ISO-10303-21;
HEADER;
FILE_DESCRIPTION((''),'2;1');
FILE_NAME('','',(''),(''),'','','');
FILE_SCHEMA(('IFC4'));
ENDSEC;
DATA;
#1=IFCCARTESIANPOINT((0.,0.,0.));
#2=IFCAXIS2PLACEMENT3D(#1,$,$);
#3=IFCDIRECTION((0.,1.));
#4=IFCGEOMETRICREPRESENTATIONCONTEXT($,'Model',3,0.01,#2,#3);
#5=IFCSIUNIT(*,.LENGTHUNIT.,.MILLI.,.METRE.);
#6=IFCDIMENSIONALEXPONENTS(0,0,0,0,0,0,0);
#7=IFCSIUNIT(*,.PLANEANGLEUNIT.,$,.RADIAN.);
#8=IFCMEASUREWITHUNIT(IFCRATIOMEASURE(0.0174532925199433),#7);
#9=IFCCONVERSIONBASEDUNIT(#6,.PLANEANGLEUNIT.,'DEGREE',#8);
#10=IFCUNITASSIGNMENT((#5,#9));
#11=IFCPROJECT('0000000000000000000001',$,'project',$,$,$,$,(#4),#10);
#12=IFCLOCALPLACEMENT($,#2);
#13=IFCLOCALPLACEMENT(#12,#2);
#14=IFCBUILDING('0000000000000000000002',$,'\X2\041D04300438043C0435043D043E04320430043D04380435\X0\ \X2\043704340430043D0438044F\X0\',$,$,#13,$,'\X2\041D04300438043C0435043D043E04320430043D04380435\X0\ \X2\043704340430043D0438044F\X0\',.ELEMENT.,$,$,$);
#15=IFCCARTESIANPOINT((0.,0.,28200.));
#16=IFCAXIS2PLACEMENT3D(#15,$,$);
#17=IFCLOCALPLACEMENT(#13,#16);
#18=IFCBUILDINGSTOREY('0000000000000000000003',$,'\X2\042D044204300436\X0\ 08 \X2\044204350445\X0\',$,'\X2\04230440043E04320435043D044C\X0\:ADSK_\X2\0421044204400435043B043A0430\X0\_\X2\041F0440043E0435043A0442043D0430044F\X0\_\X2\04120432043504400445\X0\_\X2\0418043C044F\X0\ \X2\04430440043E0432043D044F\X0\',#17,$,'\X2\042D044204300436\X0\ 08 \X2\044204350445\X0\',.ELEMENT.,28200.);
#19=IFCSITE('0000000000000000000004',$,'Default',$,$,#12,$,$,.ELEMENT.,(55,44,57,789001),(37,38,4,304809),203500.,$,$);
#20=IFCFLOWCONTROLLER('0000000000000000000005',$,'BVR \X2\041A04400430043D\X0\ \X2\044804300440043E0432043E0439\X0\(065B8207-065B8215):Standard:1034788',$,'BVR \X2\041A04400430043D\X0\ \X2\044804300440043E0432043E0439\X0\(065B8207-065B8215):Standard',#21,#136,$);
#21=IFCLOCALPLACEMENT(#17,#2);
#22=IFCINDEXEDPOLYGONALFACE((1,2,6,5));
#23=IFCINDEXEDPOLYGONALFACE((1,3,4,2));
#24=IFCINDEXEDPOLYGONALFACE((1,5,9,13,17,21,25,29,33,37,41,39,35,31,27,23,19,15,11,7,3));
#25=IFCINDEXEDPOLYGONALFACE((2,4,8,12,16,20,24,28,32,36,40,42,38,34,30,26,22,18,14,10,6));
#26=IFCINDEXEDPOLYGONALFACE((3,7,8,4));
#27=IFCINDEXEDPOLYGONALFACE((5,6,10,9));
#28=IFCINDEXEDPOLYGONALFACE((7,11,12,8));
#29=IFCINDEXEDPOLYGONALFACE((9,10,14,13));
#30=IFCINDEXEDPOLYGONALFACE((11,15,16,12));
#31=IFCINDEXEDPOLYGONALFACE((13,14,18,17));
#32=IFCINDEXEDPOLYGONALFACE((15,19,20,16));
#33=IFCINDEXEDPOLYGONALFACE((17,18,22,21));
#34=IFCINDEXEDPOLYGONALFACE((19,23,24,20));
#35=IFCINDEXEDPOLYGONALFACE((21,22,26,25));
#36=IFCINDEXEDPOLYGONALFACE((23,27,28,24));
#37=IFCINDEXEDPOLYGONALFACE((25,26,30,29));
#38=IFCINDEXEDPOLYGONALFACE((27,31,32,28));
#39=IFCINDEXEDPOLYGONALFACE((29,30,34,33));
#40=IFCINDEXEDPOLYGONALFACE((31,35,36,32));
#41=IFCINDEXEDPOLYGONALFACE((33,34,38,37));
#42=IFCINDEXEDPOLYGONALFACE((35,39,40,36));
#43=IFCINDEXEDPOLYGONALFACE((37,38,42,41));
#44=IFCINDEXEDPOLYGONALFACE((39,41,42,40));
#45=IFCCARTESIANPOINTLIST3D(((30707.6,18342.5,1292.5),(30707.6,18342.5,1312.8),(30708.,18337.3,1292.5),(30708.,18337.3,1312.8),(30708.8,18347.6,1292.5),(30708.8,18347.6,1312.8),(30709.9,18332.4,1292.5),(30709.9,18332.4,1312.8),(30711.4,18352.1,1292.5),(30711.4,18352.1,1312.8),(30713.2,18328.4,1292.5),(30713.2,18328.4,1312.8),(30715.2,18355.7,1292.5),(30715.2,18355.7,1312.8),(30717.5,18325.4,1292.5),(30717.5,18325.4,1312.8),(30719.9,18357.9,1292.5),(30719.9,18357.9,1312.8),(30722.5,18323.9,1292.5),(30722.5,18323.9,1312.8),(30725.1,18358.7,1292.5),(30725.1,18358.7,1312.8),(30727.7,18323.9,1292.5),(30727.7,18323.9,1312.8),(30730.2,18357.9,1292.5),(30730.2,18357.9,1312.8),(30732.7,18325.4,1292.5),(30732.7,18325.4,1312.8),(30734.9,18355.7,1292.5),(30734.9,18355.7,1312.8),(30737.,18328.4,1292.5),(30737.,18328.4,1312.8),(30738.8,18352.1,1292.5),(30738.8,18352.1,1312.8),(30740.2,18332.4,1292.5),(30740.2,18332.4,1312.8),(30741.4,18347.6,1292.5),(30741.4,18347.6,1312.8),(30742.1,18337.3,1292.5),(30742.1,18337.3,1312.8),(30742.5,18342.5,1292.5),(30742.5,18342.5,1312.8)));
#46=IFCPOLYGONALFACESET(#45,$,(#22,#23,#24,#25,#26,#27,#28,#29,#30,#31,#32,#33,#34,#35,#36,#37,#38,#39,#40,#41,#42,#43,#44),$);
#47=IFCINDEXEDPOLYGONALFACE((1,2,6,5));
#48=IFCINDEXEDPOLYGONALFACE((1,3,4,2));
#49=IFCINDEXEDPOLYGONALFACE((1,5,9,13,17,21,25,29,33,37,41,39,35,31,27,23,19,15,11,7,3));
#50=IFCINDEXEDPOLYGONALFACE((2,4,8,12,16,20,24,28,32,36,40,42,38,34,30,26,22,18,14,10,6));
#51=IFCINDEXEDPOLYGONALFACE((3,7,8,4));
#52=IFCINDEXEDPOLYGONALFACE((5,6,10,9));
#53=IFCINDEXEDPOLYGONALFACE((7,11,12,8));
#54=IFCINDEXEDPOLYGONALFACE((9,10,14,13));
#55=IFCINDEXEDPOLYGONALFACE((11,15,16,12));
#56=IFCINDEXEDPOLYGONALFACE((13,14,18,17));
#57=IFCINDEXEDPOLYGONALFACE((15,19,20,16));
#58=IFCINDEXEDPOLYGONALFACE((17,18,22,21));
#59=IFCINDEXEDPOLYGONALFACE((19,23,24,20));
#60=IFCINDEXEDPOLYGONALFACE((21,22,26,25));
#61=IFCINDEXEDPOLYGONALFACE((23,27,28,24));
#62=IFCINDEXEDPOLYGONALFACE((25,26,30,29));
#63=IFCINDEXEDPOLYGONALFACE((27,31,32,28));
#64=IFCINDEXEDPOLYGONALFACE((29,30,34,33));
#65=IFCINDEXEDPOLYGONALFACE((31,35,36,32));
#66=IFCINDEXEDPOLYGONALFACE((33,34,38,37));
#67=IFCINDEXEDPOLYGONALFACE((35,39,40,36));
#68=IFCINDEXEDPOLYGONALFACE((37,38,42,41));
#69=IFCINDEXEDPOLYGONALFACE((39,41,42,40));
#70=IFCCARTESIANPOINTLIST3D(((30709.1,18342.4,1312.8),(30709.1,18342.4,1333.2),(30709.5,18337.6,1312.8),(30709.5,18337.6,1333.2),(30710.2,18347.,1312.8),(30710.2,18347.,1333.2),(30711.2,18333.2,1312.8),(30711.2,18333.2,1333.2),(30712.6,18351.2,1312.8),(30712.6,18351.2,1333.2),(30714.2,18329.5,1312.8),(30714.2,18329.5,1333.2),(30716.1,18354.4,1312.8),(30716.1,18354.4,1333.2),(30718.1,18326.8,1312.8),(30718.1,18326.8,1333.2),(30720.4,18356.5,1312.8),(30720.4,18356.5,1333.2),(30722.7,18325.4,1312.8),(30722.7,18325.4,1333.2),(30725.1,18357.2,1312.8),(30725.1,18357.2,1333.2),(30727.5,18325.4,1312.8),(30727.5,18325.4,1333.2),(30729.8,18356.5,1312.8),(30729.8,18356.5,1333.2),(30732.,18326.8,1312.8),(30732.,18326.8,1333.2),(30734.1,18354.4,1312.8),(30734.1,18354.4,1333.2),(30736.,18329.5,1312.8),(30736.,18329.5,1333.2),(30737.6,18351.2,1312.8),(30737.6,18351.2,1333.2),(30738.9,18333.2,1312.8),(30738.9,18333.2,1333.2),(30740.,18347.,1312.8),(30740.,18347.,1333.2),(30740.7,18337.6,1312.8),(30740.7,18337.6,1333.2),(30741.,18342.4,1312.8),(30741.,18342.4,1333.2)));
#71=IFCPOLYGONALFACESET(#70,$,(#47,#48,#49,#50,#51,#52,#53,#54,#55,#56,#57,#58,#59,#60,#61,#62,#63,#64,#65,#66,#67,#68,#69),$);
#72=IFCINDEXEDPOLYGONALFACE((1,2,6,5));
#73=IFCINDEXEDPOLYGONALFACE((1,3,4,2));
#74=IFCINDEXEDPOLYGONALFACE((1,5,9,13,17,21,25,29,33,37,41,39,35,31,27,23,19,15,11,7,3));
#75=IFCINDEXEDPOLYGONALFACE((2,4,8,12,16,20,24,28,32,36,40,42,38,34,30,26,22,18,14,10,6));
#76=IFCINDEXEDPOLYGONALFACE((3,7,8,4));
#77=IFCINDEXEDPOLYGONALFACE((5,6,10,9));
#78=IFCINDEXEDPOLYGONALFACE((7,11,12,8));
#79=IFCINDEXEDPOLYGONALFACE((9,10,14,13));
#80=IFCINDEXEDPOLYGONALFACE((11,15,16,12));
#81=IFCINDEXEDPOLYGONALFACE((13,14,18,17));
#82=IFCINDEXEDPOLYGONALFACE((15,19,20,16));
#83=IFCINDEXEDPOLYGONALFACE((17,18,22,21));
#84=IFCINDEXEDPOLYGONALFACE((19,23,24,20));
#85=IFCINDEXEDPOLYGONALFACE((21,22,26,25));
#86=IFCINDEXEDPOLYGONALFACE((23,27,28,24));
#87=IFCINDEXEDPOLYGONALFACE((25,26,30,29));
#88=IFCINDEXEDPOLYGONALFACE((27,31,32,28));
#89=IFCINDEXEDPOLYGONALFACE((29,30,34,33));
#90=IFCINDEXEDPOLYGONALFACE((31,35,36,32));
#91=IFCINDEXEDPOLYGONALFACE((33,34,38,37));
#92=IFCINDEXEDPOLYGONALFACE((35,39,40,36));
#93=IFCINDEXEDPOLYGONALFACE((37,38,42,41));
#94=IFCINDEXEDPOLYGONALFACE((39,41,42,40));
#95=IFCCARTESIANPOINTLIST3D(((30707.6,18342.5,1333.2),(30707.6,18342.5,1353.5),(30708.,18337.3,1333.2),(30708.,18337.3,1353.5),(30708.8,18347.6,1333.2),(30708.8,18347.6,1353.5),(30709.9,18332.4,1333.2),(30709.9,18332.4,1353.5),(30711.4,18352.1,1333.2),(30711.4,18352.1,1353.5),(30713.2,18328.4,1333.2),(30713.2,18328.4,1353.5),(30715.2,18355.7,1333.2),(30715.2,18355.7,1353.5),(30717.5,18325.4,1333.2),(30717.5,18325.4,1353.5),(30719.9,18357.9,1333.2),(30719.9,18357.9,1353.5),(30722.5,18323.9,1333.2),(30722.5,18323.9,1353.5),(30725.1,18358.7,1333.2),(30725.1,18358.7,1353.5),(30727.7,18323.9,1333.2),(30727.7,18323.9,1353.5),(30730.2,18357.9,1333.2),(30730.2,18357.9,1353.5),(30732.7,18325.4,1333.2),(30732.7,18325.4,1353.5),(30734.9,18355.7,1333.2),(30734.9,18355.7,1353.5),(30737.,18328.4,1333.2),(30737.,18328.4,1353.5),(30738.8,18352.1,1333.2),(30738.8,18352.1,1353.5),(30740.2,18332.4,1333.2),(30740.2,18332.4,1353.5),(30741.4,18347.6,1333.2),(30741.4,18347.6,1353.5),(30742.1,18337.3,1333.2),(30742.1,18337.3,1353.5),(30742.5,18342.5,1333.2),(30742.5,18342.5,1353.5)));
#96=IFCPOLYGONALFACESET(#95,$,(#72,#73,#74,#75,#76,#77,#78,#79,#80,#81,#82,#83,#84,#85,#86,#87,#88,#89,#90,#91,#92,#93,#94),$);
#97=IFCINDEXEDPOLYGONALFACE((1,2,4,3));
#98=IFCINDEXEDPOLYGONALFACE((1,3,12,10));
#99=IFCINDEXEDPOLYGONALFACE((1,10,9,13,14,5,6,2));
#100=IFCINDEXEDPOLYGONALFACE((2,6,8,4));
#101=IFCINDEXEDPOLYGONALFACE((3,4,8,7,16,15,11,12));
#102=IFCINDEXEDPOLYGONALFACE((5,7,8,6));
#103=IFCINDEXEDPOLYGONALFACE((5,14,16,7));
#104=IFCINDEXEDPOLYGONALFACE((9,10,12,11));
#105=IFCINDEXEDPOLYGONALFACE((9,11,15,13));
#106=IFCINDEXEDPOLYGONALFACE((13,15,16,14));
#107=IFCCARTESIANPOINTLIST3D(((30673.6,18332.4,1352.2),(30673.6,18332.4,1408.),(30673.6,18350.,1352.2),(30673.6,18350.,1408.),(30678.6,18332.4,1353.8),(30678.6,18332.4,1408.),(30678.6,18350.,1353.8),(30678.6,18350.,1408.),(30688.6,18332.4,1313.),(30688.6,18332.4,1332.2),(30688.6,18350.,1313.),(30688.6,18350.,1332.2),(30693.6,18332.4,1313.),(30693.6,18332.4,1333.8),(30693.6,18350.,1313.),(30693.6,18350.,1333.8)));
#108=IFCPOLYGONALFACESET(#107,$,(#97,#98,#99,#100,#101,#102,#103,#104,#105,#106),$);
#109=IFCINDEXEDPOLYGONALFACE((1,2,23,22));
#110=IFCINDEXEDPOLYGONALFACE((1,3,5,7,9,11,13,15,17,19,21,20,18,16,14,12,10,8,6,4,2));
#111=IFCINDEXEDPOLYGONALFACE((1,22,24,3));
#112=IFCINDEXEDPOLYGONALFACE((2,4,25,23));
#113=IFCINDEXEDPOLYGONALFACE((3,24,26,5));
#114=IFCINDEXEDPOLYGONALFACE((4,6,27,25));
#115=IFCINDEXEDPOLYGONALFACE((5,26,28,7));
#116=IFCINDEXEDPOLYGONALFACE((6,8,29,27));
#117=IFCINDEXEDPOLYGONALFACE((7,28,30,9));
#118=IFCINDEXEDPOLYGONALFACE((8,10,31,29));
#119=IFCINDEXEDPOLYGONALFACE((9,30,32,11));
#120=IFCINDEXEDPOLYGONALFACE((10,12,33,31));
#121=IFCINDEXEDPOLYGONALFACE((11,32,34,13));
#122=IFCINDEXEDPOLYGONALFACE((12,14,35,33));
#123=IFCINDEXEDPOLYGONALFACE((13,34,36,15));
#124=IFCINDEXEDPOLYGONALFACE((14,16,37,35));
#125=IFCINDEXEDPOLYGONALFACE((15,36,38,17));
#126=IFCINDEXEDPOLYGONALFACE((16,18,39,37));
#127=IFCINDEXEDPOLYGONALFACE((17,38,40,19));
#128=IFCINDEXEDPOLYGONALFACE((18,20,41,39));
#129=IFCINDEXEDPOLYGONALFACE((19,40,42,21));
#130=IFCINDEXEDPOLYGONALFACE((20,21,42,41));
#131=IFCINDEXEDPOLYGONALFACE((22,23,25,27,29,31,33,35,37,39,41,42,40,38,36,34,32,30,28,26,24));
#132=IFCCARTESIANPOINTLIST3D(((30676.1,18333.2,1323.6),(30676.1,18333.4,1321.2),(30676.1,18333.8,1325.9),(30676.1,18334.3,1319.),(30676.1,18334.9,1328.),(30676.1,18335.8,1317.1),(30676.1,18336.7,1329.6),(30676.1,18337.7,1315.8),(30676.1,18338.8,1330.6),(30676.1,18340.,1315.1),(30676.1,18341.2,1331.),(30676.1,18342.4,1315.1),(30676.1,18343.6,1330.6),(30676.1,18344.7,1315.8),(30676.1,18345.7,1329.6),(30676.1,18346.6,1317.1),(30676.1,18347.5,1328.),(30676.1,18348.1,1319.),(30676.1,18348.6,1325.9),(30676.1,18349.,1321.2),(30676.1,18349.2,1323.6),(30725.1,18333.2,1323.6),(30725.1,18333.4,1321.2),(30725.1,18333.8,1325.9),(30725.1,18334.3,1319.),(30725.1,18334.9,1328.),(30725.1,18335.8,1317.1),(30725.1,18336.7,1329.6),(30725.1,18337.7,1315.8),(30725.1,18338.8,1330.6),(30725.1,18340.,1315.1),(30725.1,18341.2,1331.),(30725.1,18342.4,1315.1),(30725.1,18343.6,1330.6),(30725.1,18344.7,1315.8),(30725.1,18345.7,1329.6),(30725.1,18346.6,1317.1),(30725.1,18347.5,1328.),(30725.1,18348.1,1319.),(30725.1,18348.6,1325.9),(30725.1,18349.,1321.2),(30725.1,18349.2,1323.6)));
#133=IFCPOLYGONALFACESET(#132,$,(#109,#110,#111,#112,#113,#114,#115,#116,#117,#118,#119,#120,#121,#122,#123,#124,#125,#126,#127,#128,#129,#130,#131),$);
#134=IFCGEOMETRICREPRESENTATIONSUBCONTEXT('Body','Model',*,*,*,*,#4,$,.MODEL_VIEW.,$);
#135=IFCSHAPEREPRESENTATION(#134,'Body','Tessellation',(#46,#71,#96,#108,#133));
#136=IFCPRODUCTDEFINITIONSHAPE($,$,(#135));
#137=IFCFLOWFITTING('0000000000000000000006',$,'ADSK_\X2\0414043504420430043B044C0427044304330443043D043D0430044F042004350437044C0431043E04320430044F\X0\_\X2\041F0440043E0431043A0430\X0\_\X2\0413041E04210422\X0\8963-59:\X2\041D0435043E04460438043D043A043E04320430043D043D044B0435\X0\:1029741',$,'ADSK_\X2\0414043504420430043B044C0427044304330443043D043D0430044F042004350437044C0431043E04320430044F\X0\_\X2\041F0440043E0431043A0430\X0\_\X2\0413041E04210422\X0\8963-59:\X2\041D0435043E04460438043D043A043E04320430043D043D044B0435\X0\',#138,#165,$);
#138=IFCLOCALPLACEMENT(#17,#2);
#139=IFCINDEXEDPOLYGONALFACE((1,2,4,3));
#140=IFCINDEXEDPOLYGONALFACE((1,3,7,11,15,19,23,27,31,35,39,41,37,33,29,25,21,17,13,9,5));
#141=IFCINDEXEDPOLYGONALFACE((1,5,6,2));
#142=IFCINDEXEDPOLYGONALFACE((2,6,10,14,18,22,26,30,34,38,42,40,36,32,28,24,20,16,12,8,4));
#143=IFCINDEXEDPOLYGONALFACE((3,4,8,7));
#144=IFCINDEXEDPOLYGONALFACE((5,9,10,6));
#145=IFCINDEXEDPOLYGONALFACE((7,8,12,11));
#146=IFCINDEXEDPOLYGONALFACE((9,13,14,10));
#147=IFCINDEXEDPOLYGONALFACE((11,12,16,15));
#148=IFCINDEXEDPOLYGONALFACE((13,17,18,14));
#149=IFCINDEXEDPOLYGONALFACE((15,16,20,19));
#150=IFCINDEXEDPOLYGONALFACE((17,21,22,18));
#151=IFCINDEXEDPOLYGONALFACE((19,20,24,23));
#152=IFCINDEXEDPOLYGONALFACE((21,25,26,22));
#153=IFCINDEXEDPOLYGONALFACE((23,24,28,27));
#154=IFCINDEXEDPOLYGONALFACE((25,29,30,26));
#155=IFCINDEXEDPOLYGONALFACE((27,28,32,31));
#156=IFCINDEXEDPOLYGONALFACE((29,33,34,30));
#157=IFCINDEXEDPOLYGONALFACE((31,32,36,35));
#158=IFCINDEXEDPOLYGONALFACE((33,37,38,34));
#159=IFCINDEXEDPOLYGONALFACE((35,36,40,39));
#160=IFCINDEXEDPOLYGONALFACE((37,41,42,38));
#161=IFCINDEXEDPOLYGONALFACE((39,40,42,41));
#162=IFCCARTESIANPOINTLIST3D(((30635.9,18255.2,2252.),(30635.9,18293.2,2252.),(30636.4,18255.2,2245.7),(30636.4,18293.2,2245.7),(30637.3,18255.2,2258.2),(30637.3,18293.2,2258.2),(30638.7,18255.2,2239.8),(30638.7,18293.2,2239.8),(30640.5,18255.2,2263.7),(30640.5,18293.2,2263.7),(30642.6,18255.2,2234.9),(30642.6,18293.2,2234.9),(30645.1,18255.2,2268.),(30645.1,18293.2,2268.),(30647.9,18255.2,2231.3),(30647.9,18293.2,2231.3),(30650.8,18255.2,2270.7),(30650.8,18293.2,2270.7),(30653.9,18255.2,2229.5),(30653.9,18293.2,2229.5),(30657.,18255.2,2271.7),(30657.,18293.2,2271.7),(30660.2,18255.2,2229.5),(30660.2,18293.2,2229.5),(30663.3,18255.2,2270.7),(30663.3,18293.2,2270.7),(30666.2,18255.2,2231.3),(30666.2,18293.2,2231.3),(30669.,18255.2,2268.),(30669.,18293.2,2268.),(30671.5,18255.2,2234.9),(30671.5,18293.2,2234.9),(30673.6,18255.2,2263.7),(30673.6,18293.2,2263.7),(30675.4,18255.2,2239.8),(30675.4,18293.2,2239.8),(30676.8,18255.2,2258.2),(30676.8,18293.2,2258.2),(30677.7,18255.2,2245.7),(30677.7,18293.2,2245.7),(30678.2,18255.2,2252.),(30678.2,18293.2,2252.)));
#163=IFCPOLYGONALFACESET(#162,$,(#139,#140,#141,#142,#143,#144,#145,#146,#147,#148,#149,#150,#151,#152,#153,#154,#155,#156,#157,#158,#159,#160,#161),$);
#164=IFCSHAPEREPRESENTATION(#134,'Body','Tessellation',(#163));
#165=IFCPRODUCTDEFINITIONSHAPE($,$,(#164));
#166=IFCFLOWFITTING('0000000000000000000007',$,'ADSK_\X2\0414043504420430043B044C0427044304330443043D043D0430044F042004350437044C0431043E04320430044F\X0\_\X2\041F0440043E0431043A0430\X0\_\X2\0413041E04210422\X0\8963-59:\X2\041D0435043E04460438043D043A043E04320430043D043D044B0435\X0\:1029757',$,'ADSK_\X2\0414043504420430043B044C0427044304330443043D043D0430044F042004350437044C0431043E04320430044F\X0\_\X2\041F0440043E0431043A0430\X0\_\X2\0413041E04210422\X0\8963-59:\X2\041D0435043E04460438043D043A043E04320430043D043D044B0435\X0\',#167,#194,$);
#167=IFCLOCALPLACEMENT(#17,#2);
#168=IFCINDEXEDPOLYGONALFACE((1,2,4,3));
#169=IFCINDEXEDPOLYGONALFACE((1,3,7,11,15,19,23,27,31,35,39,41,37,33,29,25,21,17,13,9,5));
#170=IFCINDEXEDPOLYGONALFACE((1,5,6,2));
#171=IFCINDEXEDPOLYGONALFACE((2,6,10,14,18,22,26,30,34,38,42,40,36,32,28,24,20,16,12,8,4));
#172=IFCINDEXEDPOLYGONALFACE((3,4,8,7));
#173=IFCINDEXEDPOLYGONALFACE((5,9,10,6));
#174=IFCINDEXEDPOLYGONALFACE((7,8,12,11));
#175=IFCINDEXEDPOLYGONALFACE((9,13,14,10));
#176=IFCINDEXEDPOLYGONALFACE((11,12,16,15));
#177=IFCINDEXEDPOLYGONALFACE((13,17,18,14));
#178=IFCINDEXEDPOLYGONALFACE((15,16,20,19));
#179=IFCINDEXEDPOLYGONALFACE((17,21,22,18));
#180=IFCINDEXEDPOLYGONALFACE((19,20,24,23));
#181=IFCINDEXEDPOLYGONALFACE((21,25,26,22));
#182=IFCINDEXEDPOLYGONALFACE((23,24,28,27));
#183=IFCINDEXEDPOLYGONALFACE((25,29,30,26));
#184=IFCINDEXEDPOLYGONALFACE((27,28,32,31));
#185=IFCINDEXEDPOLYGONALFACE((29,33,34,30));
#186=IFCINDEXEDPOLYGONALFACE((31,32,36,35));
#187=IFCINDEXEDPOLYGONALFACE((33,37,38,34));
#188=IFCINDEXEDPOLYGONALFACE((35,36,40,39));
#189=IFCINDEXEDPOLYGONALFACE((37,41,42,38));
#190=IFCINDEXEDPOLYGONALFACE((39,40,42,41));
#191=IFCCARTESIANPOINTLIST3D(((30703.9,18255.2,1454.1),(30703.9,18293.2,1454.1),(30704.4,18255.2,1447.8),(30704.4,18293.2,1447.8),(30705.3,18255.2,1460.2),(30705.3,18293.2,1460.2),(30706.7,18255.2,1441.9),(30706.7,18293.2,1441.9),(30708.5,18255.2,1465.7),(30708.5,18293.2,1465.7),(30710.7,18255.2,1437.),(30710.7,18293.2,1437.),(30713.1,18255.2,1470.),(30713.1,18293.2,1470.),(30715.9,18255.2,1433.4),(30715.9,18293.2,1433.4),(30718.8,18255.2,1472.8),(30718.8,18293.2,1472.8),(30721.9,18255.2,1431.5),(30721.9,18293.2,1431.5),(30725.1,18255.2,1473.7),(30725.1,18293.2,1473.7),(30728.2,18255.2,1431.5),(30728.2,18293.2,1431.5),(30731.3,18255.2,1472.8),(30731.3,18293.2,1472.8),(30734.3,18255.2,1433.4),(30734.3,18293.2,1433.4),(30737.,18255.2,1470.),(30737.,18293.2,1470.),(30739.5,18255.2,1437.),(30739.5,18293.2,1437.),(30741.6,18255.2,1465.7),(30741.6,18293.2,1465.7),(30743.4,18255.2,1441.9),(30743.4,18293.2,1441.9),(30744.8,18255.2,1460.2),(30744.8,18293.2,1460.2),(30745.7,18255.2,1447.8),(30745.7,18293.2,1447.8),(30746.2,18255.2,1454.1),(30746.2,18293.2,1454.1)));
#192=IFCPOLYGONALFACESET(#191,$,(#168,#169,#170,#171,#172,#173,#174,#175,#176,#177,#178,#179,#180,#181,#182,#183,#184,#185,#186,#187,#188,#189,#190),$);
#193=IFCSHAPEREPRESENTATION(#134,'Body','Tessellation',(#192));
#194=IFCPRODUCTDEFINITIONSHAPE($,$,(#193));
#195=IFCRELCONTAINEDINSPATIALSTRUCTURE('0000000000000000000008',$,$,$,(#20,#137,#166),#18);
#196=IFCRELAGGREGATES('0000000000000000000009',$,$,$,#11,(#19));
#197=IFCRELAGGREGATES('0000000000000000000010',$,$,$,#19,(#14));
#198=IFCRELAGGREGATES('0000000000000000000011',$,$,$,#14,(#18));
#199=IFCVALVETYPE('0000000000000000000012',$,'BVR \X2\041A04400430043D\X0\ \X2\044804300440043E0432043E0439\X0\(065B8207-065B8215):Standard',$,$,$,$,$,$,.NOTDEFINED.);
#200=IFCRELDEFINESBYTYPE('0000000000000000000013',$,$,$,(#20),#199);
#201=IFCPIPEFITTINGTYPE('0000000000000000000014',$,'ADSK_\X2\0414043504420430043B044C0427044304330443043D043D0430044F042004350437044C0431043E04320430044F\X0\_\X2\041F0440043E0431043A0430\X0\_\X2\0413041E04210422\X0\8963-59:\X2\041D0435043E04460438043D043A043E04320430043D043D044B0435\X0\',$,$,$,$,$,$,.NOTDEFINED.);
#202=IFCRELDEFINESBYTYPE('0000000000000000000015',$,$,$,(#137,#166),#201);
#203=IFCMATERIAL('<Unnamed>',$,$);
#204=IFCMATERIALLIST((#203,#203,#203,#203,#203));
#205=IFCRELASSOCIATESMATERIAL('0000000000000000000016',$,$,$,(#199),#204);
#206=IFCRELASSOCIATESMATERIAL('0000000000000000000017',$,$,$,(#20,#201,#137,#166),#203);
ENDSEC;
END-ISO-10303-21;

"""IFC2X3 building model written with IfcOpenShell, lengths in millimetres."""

from ifc_helpers import new_model, entity, si_unit, converted_unit, direction, frame, origin, origin_2d_with_axis, place, context, subcontext, project, spatial, polyline, circle, outline, extrude, source, transform, mapped, material, material_list, type_object, type_shapes, element, save


model = new_model("IFC2X3")

# Units and contexts
model_context = context("Model", 3, precision=0.01, world=origin(), true_north=direction((0.0, 1.0)))
body_context = subcontext(model_context, "Body", "Model", "MODEL_VIEW")
ifc_project = project(units=[si_unit("LENGTHUNIT", "METRE", prefix="MILLI"), converted_unit("PLANEANGLEUNIT", "DEGREE", entity("IfcRatioMeasure", 0.0174532925199433), si_unit("PLANEANGLEUNIT", "RADIAN"), dimensions=[0, 0, 0, 0, 0, 0, 0])], contexts=[model_context])

# Site, building, storey
site_placement = place(None, origin())
site = spatial("IfcSite", under=ifc_project, at=site_placement, Name="Default", CompositionType="ELEMENT", RefLatitude=(55, 44, 57, 789001), RefLongitude=(37, 38, 4, 304809), RefElevation=203500.0)
building_placement = place(site_placement, origin())
building = spatial("IfcBuilding", under=site, at=building_placement, Name="Наименование здания", LongName="Наименование здания", CompositionType="ELEMENT")
storey_placement = place(building_placement, frame((0.0, 0.0, 28200.0)))
storey = spatial("IfcBuildingStorey", under=building, at=storey_placement, Name="Этаж 08 тех", ObjectType="Уровень:ADSK_Стрелка_Проектная_Вверх_Имя уровня", LongName="Этаж 08 тех", CompositionType="ELEMENT", Elevation=28200.0)

# Flow controller
ifc_material = material(Name="<Unnamed>")
ifc_material_list = material_list([ifc_material, ifc_material, ifc_material, ifc_material, ifc_material])
valve_type = type_object("IfcValveType", Name="BVR Кран шаровой(065B8207-065B8215):Standard", PredefinedType="NOTDEFINED", material=ifc_material_list)
shared_shape_1 = source(origin(), body_context, "Body", "SweptSolid", [
    extrude(circle(Radius=17.5, at=origin_2d_with_axis()), frame((-30.5, 0.0, 0.0), z_axis=(1.0, 0.0, 0.0), x_axis=(0.0, 1.0, 0.0)), (0.0, 0.0, 1.0), 20.3),
    extrude(circle(Radius=16.0, at=origin_2d_with_axis()), frame((-10.2, 0.0, 0.0), z_axis=(1.0, 0.0, 0.0), x_axis=(0.0, 1.0, 0.0)), (0.0, 0.0, 1.0), 20.3),
    extrude(circle(Radius=17.5, at=origin_2d_with_axis()), frame((10.2, 0.0, 0.0), z_axis=(1.0, 0.0, 0.0), x_axis=(0.0, 1.0, 0.0)), (0.0, 0.0, 1.0), 20.3),
    extrude(outline(polyline([(-38.8, -5.0), (-38.8, -10.0), (-17.9, -10.0), (2.1, 5.0), (56.2, 5.0), (56.2, 10.0), (0.4, 10.0), (-19.6, -5.0), (-38.8, -5.0)])), frame((28.8, -8.8, 41.5), z_axis=(0.0, -1.0, 0.0), x_axis=(1.0, 0.0, 0.0)), (0.0, 0.0, -1.0), 17.5),
    extrude(circle(Radius=8.0, at=origin_2d_with_axis()), origin(), (0.0, 0.0, 1.0), 49.0),
])
type_shapes(valve_type, [shared_shape_1])
flow_controller_placement = place(storey_placement, frame((30725.1, 18341.2, 1323.0), z_axis=(-1.0, 0.0, 0.0), x_axis=(0.0, 0.0, 1.0)))
element("IfcFlowController", 1, at=flow_controller_placement, inside=storey, type_object=valve_type, material=ifc_material, Name="BVR Кран шаровой(065B8207-065B8215):Standard:1034788", ObjectType="BVR Кран шаровой(065B8207-065B8215):Standard", context=body_context, shape_type="MappedRepresentation", body=[
    mapped(shared_shape_1, transform((0.0, 0.0, 0.0), scale=1.0)),
])

# Flow fittings
pipe_fitting_type = type_object("IfcPipeFittingType", Name="ADSK_ДетальЧугуннаяРезьбовая_Пробка_ГОСТ8963-59:Неоцинкованные", PredefinedType="NOTDEFINED", material=ifc_material)
shared_shape_2 = source(origin(), body_context, "Body", "SweptSolid", [
    extrude(circle(Radius=21.2, at=origin_2d_with_axis()), frame((0.0, 0.0, 0.0), z_axis=(1.0, 0.0, 0.0), x_axis=(0.0, 1.0, 0.0)), (0.0, 0.0, 1.0), 38.0),
])
type_shapes(pipe_fitting_type, [shared_shape_2])
for number, where, z_axis, x_axis, name in (
    (2, (30657.0, 18293.2, 2250.4), (-1.0, 0.0, 0.0), (0.0, -1.0, 0.0), "ADSK_ДетальЧугуннаяРезьбовая_Пробка_ГОСТ8963-59:Неоцинкованные:1029741"),
    (3, (30725.1, 18293.2, 1452.5), (-1.0, 0.0, 0.0), (0.0, -1.0, 0.0), "ADSK_ДетальЧугуннаяРезьбовая_Пробка_ГОСТ8963-59:Неоцинкованные:1029757"),
):
    element("IfcFlowFitting", number, at=place(storey_placement, frame(where, z_axis=z_axis, x_axis=x_axis)), inside=storey, type_object=pipe_fitting_type, material=ifc_material, Name=name, ObjectType="ADSK_ДетальЧугуннаяРезьбовая_Пробка_ГОСТ8963-59:Неоцинкованные", context=body_context, shape_type="MappedRepresentation", body=[
        mapped(shared_shape_2, transform((0.0, 0.0, 0.0), scale=1.0)),
    ])

save(model, "model.ifc")
